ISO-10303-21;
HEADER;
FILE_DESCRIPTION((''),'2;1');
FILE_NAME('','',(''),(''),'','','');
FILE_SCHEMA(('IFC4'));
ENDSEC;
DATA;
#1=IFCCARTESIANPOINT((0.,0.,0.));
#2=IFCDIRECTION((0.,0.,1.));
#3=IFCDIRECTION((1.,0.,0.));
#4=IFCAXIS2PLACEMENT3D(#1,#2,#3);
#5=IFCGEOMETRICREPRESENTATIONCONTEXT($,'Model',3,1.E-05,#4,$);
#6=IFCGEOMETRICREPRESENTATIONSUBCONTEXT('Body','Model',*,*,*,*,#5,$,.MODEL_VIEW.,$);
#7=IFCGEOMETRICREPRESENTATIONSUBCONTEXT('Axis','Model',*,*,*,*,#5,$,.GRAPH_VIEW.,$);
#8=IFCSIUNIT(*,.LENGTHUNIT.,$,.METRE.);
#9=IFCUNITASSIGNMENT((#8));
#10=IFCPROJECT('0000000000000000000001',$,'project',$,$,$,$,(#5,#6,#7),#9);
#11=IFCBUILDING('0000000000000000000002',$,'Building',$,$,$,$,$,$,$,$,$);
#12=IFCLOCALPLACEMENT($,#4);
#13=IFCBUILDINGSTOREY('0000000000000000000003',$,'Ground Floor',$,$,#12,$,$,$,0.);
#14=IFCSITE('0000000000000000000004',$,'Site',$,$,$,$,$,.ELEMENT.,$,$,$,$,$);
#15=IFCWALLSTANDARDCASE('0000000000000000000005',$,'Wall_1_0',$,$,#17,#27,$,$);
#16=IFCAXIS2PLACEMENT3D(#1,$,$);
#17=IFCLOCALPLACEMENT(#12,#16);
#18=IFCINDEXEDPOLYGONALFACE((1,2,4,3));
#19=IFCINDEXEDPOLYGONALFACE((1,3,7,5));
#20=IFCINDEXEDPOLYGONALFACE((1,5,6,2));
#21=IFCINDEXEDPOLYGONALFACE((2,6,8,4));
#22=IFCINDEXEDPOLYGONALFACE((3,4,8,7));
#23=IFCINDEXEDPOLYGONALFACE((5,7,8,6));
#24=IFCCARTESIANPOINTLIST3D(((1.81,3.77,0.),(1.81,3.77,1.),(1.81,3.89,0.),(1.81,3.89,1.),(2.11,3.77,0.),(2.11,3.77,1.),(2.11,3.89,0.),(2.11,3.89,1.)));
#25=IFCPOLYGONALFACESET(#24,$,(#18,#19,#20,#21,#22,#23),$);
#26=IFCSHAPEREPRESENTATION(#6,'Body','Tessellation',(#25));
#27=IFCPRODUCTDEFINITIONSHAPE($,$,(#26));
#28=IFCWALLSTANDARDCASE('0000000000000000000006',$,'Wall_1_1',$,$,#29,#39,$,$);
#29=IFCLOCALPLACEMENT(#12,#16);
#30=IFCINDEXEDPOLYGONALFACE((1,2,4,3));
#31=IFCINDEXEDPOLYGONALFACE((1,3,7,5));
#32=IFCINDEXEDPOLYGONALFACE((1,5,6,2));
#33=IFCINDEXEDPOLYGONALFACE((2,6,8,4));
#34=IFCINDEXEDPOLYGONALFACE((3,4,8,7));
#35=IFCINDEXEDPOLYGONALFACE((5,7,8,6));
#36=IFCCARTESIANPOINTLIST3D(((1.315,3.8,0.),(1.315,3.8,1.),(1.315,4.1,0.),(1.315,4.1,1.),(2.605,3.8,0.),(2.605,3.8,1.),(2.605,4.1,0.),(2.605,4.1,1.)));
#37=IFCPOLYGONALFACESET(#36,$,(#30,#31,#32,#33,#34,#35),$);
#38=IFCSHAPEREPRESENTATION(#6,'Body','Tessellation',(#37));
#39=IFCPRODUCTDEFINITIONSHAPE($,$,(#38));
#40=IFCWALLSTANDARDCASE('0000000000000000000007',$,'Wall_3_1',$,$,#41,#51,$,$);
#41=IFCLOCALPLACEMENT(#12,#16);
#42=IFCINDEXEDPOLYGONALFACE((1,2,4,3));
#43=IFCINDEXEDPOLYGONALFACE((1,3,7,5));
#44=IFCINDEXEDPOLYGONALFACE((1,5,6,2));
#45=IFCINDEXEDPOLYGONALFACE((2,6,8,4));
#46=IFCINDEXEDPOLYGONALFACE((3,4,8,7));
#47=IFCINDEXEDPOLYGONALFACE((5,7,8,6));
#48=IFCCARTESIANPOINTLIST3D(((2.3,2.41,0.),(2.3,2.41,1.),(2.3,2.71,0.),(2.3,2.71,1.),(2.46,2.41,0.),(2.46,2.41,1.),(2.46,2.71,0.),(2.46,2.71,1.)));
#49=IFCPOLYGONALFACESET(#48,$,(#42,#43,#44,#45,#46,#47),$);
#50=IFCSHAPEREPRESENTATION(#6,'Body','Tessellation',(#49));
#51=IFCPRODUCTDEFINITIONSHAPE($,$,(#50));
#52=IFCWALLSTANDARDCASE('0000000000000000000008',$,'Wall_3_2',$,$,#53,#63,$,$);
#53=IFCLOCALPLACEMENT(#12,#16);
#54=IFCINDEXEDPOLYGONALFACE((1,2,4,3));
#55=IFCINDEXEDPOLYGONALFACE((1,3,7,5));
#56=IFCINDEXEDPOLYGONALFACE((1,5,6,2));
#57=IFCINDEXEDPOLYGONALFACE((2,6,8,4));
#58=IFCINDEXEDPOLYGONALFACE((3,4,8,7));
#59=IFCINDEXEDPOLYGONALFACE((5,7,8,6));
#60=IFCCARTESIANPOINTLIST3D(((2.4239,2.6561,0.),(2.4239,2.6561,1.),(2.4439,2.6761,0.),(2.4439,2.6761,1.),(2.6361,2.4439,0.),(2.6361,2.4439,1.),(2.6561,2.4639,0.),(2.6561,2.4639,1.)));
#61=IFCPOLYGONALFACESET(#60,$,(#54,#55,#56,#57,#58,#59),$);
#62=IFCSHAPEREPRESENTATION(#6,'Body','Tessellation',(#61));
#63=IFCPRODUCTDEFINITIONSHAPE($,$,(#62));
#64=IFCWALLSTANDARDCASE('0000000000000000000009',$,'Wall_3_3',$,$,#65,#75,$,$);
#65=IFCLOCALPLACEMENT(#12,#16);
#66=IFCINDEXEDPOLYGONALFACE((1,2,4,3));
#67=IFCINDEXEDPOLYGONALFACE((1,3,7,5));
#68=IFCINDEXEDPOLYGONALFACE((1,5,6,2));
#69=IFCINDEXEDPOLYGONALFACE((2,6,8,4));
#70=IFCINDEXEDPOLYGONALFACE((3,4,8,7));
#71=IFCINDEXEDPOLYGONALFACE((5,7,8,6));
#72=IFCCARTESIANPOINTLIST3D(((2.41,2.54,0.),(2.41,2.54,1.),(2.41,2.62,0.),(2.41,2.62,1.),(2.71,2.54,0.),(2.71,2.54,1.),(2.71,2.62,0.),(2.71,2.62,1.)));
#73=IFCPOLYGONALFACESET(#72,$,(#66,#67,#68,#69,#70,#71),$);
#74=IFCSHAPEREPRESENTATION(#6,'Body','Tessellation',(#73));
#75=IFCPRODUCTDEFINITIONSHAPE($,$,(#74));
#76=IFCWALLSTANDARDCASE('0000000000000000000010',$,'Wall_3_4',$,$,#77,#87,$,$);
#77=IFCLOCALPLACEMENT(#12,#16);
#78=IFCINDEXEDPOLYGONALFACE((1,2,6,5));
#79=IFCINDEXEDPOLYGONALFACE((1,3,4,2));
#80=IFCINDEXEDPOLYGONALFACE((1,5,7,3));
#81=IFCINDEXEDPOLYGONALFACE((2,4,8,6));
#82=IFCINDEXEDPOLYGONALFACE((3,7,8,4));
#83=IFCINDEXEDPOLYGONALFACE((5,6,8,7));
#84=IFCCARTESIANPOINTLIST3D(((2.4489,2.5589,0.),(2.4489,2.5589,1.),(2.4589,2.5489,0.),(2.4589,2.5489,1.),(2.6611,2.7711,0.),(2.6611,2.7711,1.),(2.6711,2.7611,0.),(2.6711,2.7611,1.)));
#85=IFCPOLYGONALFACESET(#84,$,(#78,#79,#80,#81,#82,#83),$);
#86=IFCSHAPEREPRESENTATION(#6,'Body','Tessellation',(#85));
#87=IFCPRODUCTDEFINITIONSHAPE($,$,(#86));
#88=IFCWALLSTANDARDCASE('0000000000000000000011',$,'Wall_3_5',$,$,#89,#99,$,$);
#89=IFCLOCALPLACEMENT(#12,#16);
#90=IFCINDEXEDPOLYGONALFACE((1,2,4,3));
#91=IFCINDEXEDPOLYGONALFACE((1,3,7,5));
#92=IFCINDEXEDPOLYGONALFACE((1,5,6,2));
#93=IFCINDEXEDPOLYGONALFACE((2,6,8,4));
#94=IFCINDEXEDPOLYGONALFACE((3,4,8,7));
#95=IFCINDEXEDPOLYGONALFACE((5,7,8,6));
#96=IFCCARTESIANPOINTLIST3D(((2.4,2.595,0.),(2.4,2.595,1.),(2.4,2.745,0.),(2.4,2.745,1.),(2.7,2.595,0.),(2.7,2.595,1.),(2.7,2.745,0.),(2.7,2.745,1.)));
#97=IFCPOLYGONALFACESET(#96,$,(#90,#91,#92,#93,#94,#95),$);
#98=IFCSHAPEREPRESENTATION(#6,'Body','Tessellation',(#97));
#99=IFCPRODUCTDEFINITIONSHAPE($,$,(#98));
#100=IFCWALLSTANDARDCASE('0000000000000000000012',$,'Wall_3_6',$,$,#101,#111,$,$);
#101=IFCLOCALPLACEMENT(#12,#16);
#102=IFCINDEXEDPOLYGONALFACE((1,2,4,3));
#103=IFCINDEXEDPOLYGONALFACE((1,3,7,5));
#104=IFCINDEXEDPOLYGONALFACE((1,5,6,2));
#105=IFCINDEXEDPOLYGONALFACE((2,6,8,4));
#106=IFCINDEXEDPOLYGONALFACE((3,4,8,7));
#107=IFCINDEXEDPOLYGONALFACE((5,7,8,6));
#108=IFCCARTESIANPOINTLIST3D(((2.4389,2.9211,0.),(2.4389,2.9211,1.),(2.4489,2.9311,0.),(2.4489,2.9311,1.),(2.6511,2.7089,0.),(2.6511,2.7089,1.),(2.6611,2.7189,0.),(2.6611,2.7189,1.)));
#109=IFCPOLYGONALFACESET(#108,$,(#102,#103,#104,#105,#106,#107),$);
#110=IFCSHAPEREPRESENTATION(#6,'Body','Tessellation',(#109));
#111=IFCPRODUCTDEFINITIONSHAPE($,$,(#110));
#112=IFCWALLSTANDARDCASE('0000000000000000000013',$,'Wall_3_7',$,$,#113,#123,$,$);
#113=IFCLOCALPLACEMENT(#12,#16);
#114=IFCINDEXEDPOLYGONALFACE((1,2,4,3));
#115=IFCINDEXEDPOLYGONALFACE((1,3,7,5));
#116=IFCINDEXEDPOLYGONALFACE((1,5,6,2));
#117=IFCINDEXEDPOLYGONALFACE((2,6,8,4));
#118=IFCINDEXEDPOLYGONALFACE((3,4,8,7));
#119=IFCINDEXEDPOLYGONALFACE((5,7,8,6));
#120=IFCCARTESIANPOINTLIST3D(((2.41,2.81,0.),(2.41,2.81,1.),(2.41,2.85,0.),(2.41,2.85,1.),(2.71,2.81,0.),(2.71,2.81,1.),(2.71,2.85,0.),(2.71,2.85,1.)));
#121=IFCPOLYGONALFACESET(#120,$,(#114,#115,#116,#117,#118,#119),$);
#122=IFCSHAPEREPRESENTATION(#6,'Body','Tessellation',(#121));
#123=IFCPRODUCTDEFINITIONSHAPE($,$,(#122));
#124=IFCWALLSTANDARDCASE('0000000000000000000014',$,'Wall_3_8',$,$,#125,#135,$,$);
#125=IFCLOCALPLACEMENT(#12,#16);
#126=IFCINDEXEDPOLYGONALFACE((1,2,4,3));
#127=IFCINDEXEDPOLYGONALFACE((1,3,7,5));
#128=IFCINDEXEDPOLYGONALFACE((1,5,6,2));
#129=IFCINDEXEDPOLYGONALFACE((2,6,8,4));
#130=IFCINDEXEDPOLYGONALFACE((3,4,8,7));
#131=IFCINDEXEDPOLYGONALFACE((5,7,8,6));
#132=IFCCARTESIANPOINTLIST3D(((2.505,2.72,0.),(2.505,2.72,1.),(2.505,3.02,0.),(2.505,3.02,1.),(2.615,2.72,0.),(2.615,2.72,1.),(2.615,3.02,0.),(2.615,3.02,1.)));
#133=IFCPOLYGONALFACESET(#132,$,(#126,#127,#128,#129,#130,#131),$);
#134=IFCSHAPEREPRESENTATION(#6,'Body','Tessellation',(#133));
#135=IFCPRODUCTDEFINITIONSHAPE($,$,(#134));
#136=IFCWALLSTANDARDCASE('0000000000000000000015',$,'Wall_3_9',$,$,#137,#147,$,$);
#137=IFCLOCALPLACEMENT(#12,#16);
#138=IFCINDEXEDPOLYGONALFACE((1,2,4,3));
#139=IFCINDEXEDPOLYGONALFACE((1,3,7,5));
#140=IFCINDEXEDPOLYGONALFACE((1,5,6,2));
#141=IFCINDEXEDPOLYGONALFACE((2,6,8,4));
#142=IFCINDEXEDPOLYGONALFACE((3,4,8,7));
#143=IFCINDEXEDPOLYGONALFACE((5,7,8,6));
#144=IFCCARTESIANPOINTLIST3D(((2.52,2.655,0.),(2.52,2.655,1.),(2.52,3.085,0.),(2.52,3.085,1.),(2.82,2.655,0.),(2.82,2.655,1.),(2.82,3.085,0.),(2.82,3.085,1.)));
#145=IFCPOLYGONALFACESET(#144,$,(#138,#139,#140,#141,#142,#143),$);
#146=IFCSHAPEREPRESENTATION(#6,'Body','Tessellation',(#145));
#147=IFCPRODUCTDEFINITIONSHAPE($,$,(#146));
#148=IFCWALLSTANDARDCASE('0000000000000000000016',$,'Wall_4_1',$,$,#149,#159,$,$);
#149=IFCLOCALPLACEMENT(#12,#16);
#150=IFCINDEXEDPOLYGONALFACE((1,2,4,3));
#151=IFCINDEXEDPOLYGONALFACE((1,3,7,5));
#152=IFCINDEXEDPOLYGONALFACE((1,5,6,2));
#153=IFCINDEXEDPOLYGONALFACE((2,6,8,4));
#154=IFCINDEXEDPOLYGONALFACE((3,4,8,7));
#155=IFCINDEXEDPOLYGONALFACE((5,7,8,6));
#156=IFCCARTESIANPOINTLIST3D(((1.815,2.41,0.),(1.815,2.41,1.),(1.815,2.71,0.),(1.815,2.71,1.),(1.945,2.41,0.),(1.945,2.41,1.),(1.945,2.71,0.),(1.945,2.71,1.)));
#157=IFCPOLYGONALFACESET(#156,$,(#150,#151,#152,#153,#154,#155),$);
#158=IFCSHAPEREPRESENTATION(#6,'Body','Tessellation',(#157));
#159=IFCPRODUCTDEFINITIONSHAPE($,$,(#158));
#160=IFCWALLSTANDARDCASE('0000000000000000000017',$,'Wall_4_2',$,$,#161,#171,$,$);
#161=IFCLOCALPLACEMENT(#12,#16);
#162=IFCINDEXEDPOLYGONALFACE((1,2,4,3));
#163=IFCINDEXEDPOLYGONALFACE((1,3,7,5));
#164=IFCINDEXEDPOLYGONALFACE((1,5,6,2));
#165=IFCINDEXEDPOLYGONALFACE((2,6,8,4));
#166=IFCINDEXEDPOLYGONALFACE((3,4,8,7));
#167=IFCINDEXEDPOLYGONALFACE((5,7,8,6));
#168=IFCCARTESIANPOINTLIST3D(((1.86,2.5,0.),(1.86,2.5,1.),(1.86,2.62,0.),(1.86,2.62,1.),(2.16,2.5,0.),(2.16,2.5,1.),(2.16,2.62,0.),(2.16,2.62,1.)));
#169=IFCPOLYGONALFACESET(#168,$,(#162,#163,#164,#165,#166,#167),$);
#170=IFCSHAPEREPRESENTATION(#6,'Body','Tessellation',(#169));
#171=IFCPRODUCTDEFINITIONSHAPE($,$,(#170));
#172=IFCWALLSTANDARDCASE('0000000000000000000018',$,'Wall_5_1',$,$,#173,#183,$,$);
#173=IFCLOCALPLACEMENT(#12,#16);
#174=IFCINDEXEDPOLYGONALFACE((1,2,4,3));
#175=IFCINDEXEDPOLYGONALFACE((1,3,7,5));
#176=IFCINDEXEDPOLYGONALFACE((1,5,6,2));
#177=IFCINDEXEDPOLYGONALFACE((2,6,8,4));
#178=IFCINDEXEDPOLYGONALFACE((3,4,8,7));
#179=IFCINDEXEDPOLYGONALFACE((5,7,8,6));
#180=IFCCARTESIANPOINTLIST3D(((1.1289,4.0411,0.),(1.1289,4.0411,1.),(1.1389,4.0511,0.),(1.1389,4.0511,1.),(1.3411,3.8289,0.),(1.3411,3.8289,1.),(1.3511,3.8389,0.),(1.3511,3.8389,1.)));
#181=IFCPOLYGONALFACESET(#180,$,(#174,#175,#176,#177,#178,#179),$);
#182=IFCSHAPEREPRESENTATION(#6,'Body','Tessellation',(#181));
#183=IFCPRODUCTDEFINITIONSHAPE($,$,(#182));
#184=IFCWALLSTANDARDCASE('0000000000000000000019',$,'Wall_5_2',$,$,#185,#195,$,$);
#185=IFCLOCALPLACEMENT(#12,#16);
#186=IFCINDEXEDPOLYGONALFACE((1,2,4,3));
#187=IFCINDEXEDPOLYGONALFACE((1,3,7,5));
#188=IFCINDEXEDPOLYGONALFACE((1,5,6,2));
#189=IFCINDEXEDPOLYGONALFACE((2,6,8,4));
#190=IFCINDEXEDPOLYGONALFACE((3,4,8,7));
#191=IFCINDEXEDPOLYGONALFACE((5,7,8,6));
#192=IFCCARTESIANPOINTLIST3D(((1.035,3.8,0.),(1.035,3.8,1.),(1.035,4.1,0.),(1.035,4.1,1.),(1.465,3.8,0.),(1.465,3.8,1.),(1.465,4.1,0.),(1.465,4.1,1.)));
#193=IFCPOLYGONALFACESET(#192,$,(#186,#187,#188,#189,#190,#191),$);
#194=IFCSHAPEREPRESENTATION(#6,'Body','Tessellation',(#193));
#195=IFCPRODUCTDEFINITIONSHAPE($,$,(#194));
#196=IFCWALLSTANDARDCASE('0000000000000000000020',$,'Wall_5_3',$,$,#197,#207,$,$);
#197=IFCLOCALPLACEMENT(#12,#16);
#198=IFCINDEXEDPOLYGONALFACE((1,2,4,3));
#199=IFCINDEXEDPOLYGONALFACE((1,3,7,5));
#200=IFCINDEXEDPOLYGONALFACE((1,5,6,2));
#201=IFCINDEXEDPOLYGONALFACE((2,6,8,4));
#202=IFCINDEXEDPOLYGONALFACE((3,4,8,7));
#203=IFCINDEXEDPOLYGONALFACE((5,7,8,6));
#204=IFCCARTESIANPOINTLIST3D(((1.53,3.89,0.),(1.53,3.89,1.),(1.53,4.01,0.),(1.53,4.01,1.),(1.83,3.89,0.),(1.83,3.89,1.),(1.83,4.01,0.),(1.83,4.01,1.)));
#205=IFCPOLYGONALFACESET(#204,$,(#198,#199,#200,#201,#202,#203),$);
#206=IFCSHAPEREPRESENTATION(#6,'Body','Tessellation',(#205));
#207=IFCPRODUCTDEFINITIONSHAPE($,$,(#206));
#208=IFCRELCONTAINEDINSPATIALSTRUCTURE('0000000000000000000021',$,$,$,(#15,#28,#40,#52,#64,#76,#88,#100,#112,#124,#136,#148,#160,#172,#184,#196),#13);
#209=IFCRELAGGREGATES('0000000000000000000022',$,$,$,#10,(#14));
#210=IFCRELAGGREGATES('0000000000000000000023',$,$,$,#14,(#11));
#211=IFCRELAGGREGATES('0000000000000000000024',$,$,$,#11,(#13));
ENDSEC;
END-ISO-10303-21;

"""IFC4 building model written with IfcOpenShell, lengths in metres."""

from ifc_helpers import new_model, si_unit, frame, origin_with_axes, origin_2d, place, context, subcontext, project, spatial, rectangle, extrude, element, save


model = new_model("IFC4")

# Units and contexts
model_context = context("Model", 3, precision=1e-05, world=origin_with_axes())
body_context = subcontext(model_context, "Body", "Model", "MODEL_VIEW")
axis_context = subcontext(model_context, "Axis", "Model", "GRAPH_VIEW")
ifc_project = project(units=[si_unit("LENGTHUNIT", "METRE")], contexts=[model_context, body_context, axis_context])

# Site, building, storey
site = spatial("IfcSite", under=ifc_project, Name="Site", CompositionType="ELEMENT")
building = spatial("IfcBuilding", under=site, Name="Building")
storey_placement = place(None, origin_with_axes())
storey = spatial("IfcBuildingStorey", under=building, at=storey_placement, Name="Ground Floor", Elevation=0.0)

# Walls
wall_1_placement = place(storey_placement, frame((1.96, 3.83, 0.0), z_axis=(0.0, 0.0, 1.0), x_axis=(0.0, 1.0, 0.0)))
element("IfcWallStandardCase", 1, at=wall_1_placement, inside=storey, Name="Wall_1_0", context=body_context, shape_type="SweptSolid", body=[
    extrude(rectangle(XDim=0.12, YDim=0.3, at=origin_2d()), origin_with_axes(), (0.0, 0.0, 1.0), 1.0),
])
wall_2_placement = place(storey_placement, frame((1.96, 3.95, 0.0), z_axis=(0.0, 0.0, 1.0), x_axis=(1.0, 0.0, 0.0)))
element("IfcWallStandardCase", 2, at=wall_2_placement, inside=storey, Name="Wall_1_1", context=body_context, shape_type="SweptSolid", body=[
    extrude(rectangle(XDim=1.29, YDim=0.3, at=origin_2d()), origin_with_axes(), (0.0, 0.0, 1.0), 1.0),
])
wall_3_placement = place(storey_placement, frame((2.38, 2.56, 0.0), z_axis=(0.0, 0.0, 1.0), x_axis=(1.0, 0.0, 0.0)))
element("IfcWallStandardCase", 3, at=wall_3_placement, inside=storey, Name="Wall_3_1", context=body_context, shape_type="SweptSolid", body=[
    extrude(rectangle(XDim=0.16, YDim=0.3, at=origin_2d()), origin_with_axes(), (0.0, 0.0, 1.0), 1.0),
])
wall_4_placement = place(storey_placement, frame((2.54, 2.56, 0.0), z_axis=(0.0, 0.0, 1.0), x_axis=(0.707107, 0.707107, 0.0)))
element("IfcWallStandardCase", 4, at=wall_4_placement, inside=storey, Name="Wall_3_2", context=body_context, shape_type="SweptSolid", body=[
    extrude(rectangle(XDim=0.0283, YDim=0.3, at=origin_2d()), origin_with_axes(), (0.0, 0.0, 1.0), 1.0),
])
wall_5_placement = place(storey_placement, frame((2.56, 2.58, 0.0), z_axis=(0.0, 0.0, 1.0), x_axis=(0.0, 1.0, 0.0)))
element("IfcWallStandardCase", 5, at=wall_5_placement, inside=storey, Name="Wall_3_3", context=body_context, shape_type="SweptSolid", body=[
    extrude(rectangle(XDim=0.08, YDim=0.3, at=origin_2d()), origin_with_axes(), (0.0, 0.0, 1.0), 1.0),
])
wall_6_placement = place(storey_placement, frame((2.56, 2.66, 0.0), z_axis=(0.0, 0.0, 1.0), x_axis=(-0.707107, 0.707107, 0.0)))
element("IfcWallStandardCase", 6, at=wall_6_placement, inside=storey, Name="Wall_3_4", context=body_context, shape_type="SweptSolid", body=[
    extrude(rectangle(XDim=0.0141, YDim=0.3, at=origin_2d()), origin_with_axes(), (0.0, 0.0, 1.0), 1.0),
])
wall_7_placement = place(storey_placement, frame((2.55, 2.67, 0.0), z_axis=(0.0, 0.0, 1.0), x_axis=(0.0, 1.0, 0.0)))
element("IfcWallStandardCase", 7, at=wall_7_placement, inside=storey, Name="Wall_3_5", context=body_context, shape_type="SweptSolid", body=[
    extrude(rectangle(XDim=0.15, YDim=0.3, at=origin_2d()), origin_with_axes(), (0.0, 0.0, 1.0), 1.0),
])
wall_8_placement = place(storey_placement, frame((2.55, 2.82, 0.0), z_axis=(0.0, 0.0, 1.0), x_axis=(0.707107, 0.707107, 0.0)))
element("IfcWallStandardCase", 8, at=wall_8_placement, inside=storey, Name="Wall_3_6", context=body_context, shape_type="SweptSolid", body=[
    extrude(rectangle(XDim=0.0141, YDim=0.3, at=origin_2d()), origin_with_axes(), (0.0, 0.0, 1.0), 1.0),
])
wall_9_placement = place(storey_placement, frame((2.56, 2.83, 0.0), z_axis=(0.0, 0.0, 1.0), x_axis=(0.0, 1.0, 0.0)))
element("IfcWallStandardCase", 9, at=wall_9_placement, inside=storey, Name="Wall_3_7", context=body_context, shape_type="SweptSolid", body=[
    extrude(rectangle(XDim=0.04, YDim=0.3, at=origin_2d()), origin_with_axes(), (0.0, 0.0, 1.0), 1.0),
])
wall_10_placement = place(storey_placement, frame((2.56, 2.87, 0.0), z_axis=(0.0, 0.0, 1.0), x_axis=(1.0, 0.0, 0.0)))
element("IfcWallStandardCase", 10, at=wall_10_placement, inside=storey, Name="Wall_3_8", context=body_context, shape_type="SweptSolid", body=[
    extrude(rectangle(XDim=0.11, YDim=0.3, at=origin_2d()), origin_with_axes(), (0.0, 0.0, 1.0), 1.0),
])
wall_11_placement = place(storey_placement, frame((2.67, 2.87, 0.0), z_axis=(0.0, 0.0, 1.0), x_axis=(0.0, -1.0, 0.0)))
element("IfcWallStandardCase", 11, at=wall_11_placement, inside=storey, Name="Wall_3_9", context=body_context, shape_type="SweptSolid", body=[
    extrude(rectangle(XDim=0.43, YDim=0.3, at=origin_2d()), origin_with_axes(), (0.0, 0.0, 1.0), 1.0),
])
wall_12_placement = place(storey_placement, frame((1.88, 2.56, 0.0), z_axis=(0.0, 0.0, 1.0), x_axis=(1.0, 0.0, 0.0)))
element("IfcWallStandardCase", 12, at=wall_12_placement, inside=storey, Name="Wall_4_1", context=body_context, shape_type="SweptSolid", body=[
    extrude(rectangle(XDim=0.13, YDim=0.3, at=origin_2d()), origin_with_axes(), (0.0, 0.0, 1.0), 1.0),
])
wall_13_placement = place(storey_placement, frame((2.01, 2.56, 0.0), z_axis=(0.0, 0.0, 1.0), x_axis=(0.0, -1.0, 0.0)))
element("IfcWallStandardCase", 13, at=wall_13_placement, inside=storey, Name="Wall_4_2", context=body_context, shape_type="SweptSolid", body=[
    extrude(rectangle(XDim=0.12, YDim=0.3, at=origin_2d()), origin_with_axes(), (0.0, 0.0, 1.0), 1.0),
])
wall_14_placement = place(storey_placement, frame((1.24, 3.94, 0.0), z_axis=(0.0, 0.0, 1.0), x_axis=(0.707107, 0.707107, 0.0)))
element("IfcWallStandardCase", 14, at=wall_14_placement, inside=storey, Name="Wall_5_1", context=body_context, shape_type="SweptSolid", body=[
    extrude(rectangle(XDim=0.0141, YDim=0.3, at=origin_2d()), origin_with_axes(), (0.0, 0.0, 1.0), 1.0),
])
wall_15_placement = place(storey_placement, frame((1.25, 3.95, 0.0), z_axis=(0.0, 0.0, 1.0), x_axis=(1.0, 0.0, 0.0)))
element("IfcWallStandardCase", 15, at=wall_15_placement, inside=storey, Name="Wall_5_2", context=body_context, shape_type="SweptSolid", body=[
    extrude(rectangle(XDim=0.43, YDim=0.3, at=origin_2d()), origin_with_axes(), (0.0, 0.0, 1.0), 1.0),
])
wall_16_placement = place(storey_placement, frame((1.68, 3.95, 0.0), z_axis=(0.0, 0.0, 1.0), x_axis=(0.0, -1.0, 0.0)))
element("IfcWallStandardCase", 16, at=wall_16_placement, inside=storey, Name="Wall_5_3", context=body_context, shape_type="SweptSolid", body=[
    extrude(rectangle(XDim=0.12, YDim=0.3, at=origin_2d()), origin_with_axes(), (0.0, 0.0, 1.0), 1.0),
])

save(model, "model.ifc")
